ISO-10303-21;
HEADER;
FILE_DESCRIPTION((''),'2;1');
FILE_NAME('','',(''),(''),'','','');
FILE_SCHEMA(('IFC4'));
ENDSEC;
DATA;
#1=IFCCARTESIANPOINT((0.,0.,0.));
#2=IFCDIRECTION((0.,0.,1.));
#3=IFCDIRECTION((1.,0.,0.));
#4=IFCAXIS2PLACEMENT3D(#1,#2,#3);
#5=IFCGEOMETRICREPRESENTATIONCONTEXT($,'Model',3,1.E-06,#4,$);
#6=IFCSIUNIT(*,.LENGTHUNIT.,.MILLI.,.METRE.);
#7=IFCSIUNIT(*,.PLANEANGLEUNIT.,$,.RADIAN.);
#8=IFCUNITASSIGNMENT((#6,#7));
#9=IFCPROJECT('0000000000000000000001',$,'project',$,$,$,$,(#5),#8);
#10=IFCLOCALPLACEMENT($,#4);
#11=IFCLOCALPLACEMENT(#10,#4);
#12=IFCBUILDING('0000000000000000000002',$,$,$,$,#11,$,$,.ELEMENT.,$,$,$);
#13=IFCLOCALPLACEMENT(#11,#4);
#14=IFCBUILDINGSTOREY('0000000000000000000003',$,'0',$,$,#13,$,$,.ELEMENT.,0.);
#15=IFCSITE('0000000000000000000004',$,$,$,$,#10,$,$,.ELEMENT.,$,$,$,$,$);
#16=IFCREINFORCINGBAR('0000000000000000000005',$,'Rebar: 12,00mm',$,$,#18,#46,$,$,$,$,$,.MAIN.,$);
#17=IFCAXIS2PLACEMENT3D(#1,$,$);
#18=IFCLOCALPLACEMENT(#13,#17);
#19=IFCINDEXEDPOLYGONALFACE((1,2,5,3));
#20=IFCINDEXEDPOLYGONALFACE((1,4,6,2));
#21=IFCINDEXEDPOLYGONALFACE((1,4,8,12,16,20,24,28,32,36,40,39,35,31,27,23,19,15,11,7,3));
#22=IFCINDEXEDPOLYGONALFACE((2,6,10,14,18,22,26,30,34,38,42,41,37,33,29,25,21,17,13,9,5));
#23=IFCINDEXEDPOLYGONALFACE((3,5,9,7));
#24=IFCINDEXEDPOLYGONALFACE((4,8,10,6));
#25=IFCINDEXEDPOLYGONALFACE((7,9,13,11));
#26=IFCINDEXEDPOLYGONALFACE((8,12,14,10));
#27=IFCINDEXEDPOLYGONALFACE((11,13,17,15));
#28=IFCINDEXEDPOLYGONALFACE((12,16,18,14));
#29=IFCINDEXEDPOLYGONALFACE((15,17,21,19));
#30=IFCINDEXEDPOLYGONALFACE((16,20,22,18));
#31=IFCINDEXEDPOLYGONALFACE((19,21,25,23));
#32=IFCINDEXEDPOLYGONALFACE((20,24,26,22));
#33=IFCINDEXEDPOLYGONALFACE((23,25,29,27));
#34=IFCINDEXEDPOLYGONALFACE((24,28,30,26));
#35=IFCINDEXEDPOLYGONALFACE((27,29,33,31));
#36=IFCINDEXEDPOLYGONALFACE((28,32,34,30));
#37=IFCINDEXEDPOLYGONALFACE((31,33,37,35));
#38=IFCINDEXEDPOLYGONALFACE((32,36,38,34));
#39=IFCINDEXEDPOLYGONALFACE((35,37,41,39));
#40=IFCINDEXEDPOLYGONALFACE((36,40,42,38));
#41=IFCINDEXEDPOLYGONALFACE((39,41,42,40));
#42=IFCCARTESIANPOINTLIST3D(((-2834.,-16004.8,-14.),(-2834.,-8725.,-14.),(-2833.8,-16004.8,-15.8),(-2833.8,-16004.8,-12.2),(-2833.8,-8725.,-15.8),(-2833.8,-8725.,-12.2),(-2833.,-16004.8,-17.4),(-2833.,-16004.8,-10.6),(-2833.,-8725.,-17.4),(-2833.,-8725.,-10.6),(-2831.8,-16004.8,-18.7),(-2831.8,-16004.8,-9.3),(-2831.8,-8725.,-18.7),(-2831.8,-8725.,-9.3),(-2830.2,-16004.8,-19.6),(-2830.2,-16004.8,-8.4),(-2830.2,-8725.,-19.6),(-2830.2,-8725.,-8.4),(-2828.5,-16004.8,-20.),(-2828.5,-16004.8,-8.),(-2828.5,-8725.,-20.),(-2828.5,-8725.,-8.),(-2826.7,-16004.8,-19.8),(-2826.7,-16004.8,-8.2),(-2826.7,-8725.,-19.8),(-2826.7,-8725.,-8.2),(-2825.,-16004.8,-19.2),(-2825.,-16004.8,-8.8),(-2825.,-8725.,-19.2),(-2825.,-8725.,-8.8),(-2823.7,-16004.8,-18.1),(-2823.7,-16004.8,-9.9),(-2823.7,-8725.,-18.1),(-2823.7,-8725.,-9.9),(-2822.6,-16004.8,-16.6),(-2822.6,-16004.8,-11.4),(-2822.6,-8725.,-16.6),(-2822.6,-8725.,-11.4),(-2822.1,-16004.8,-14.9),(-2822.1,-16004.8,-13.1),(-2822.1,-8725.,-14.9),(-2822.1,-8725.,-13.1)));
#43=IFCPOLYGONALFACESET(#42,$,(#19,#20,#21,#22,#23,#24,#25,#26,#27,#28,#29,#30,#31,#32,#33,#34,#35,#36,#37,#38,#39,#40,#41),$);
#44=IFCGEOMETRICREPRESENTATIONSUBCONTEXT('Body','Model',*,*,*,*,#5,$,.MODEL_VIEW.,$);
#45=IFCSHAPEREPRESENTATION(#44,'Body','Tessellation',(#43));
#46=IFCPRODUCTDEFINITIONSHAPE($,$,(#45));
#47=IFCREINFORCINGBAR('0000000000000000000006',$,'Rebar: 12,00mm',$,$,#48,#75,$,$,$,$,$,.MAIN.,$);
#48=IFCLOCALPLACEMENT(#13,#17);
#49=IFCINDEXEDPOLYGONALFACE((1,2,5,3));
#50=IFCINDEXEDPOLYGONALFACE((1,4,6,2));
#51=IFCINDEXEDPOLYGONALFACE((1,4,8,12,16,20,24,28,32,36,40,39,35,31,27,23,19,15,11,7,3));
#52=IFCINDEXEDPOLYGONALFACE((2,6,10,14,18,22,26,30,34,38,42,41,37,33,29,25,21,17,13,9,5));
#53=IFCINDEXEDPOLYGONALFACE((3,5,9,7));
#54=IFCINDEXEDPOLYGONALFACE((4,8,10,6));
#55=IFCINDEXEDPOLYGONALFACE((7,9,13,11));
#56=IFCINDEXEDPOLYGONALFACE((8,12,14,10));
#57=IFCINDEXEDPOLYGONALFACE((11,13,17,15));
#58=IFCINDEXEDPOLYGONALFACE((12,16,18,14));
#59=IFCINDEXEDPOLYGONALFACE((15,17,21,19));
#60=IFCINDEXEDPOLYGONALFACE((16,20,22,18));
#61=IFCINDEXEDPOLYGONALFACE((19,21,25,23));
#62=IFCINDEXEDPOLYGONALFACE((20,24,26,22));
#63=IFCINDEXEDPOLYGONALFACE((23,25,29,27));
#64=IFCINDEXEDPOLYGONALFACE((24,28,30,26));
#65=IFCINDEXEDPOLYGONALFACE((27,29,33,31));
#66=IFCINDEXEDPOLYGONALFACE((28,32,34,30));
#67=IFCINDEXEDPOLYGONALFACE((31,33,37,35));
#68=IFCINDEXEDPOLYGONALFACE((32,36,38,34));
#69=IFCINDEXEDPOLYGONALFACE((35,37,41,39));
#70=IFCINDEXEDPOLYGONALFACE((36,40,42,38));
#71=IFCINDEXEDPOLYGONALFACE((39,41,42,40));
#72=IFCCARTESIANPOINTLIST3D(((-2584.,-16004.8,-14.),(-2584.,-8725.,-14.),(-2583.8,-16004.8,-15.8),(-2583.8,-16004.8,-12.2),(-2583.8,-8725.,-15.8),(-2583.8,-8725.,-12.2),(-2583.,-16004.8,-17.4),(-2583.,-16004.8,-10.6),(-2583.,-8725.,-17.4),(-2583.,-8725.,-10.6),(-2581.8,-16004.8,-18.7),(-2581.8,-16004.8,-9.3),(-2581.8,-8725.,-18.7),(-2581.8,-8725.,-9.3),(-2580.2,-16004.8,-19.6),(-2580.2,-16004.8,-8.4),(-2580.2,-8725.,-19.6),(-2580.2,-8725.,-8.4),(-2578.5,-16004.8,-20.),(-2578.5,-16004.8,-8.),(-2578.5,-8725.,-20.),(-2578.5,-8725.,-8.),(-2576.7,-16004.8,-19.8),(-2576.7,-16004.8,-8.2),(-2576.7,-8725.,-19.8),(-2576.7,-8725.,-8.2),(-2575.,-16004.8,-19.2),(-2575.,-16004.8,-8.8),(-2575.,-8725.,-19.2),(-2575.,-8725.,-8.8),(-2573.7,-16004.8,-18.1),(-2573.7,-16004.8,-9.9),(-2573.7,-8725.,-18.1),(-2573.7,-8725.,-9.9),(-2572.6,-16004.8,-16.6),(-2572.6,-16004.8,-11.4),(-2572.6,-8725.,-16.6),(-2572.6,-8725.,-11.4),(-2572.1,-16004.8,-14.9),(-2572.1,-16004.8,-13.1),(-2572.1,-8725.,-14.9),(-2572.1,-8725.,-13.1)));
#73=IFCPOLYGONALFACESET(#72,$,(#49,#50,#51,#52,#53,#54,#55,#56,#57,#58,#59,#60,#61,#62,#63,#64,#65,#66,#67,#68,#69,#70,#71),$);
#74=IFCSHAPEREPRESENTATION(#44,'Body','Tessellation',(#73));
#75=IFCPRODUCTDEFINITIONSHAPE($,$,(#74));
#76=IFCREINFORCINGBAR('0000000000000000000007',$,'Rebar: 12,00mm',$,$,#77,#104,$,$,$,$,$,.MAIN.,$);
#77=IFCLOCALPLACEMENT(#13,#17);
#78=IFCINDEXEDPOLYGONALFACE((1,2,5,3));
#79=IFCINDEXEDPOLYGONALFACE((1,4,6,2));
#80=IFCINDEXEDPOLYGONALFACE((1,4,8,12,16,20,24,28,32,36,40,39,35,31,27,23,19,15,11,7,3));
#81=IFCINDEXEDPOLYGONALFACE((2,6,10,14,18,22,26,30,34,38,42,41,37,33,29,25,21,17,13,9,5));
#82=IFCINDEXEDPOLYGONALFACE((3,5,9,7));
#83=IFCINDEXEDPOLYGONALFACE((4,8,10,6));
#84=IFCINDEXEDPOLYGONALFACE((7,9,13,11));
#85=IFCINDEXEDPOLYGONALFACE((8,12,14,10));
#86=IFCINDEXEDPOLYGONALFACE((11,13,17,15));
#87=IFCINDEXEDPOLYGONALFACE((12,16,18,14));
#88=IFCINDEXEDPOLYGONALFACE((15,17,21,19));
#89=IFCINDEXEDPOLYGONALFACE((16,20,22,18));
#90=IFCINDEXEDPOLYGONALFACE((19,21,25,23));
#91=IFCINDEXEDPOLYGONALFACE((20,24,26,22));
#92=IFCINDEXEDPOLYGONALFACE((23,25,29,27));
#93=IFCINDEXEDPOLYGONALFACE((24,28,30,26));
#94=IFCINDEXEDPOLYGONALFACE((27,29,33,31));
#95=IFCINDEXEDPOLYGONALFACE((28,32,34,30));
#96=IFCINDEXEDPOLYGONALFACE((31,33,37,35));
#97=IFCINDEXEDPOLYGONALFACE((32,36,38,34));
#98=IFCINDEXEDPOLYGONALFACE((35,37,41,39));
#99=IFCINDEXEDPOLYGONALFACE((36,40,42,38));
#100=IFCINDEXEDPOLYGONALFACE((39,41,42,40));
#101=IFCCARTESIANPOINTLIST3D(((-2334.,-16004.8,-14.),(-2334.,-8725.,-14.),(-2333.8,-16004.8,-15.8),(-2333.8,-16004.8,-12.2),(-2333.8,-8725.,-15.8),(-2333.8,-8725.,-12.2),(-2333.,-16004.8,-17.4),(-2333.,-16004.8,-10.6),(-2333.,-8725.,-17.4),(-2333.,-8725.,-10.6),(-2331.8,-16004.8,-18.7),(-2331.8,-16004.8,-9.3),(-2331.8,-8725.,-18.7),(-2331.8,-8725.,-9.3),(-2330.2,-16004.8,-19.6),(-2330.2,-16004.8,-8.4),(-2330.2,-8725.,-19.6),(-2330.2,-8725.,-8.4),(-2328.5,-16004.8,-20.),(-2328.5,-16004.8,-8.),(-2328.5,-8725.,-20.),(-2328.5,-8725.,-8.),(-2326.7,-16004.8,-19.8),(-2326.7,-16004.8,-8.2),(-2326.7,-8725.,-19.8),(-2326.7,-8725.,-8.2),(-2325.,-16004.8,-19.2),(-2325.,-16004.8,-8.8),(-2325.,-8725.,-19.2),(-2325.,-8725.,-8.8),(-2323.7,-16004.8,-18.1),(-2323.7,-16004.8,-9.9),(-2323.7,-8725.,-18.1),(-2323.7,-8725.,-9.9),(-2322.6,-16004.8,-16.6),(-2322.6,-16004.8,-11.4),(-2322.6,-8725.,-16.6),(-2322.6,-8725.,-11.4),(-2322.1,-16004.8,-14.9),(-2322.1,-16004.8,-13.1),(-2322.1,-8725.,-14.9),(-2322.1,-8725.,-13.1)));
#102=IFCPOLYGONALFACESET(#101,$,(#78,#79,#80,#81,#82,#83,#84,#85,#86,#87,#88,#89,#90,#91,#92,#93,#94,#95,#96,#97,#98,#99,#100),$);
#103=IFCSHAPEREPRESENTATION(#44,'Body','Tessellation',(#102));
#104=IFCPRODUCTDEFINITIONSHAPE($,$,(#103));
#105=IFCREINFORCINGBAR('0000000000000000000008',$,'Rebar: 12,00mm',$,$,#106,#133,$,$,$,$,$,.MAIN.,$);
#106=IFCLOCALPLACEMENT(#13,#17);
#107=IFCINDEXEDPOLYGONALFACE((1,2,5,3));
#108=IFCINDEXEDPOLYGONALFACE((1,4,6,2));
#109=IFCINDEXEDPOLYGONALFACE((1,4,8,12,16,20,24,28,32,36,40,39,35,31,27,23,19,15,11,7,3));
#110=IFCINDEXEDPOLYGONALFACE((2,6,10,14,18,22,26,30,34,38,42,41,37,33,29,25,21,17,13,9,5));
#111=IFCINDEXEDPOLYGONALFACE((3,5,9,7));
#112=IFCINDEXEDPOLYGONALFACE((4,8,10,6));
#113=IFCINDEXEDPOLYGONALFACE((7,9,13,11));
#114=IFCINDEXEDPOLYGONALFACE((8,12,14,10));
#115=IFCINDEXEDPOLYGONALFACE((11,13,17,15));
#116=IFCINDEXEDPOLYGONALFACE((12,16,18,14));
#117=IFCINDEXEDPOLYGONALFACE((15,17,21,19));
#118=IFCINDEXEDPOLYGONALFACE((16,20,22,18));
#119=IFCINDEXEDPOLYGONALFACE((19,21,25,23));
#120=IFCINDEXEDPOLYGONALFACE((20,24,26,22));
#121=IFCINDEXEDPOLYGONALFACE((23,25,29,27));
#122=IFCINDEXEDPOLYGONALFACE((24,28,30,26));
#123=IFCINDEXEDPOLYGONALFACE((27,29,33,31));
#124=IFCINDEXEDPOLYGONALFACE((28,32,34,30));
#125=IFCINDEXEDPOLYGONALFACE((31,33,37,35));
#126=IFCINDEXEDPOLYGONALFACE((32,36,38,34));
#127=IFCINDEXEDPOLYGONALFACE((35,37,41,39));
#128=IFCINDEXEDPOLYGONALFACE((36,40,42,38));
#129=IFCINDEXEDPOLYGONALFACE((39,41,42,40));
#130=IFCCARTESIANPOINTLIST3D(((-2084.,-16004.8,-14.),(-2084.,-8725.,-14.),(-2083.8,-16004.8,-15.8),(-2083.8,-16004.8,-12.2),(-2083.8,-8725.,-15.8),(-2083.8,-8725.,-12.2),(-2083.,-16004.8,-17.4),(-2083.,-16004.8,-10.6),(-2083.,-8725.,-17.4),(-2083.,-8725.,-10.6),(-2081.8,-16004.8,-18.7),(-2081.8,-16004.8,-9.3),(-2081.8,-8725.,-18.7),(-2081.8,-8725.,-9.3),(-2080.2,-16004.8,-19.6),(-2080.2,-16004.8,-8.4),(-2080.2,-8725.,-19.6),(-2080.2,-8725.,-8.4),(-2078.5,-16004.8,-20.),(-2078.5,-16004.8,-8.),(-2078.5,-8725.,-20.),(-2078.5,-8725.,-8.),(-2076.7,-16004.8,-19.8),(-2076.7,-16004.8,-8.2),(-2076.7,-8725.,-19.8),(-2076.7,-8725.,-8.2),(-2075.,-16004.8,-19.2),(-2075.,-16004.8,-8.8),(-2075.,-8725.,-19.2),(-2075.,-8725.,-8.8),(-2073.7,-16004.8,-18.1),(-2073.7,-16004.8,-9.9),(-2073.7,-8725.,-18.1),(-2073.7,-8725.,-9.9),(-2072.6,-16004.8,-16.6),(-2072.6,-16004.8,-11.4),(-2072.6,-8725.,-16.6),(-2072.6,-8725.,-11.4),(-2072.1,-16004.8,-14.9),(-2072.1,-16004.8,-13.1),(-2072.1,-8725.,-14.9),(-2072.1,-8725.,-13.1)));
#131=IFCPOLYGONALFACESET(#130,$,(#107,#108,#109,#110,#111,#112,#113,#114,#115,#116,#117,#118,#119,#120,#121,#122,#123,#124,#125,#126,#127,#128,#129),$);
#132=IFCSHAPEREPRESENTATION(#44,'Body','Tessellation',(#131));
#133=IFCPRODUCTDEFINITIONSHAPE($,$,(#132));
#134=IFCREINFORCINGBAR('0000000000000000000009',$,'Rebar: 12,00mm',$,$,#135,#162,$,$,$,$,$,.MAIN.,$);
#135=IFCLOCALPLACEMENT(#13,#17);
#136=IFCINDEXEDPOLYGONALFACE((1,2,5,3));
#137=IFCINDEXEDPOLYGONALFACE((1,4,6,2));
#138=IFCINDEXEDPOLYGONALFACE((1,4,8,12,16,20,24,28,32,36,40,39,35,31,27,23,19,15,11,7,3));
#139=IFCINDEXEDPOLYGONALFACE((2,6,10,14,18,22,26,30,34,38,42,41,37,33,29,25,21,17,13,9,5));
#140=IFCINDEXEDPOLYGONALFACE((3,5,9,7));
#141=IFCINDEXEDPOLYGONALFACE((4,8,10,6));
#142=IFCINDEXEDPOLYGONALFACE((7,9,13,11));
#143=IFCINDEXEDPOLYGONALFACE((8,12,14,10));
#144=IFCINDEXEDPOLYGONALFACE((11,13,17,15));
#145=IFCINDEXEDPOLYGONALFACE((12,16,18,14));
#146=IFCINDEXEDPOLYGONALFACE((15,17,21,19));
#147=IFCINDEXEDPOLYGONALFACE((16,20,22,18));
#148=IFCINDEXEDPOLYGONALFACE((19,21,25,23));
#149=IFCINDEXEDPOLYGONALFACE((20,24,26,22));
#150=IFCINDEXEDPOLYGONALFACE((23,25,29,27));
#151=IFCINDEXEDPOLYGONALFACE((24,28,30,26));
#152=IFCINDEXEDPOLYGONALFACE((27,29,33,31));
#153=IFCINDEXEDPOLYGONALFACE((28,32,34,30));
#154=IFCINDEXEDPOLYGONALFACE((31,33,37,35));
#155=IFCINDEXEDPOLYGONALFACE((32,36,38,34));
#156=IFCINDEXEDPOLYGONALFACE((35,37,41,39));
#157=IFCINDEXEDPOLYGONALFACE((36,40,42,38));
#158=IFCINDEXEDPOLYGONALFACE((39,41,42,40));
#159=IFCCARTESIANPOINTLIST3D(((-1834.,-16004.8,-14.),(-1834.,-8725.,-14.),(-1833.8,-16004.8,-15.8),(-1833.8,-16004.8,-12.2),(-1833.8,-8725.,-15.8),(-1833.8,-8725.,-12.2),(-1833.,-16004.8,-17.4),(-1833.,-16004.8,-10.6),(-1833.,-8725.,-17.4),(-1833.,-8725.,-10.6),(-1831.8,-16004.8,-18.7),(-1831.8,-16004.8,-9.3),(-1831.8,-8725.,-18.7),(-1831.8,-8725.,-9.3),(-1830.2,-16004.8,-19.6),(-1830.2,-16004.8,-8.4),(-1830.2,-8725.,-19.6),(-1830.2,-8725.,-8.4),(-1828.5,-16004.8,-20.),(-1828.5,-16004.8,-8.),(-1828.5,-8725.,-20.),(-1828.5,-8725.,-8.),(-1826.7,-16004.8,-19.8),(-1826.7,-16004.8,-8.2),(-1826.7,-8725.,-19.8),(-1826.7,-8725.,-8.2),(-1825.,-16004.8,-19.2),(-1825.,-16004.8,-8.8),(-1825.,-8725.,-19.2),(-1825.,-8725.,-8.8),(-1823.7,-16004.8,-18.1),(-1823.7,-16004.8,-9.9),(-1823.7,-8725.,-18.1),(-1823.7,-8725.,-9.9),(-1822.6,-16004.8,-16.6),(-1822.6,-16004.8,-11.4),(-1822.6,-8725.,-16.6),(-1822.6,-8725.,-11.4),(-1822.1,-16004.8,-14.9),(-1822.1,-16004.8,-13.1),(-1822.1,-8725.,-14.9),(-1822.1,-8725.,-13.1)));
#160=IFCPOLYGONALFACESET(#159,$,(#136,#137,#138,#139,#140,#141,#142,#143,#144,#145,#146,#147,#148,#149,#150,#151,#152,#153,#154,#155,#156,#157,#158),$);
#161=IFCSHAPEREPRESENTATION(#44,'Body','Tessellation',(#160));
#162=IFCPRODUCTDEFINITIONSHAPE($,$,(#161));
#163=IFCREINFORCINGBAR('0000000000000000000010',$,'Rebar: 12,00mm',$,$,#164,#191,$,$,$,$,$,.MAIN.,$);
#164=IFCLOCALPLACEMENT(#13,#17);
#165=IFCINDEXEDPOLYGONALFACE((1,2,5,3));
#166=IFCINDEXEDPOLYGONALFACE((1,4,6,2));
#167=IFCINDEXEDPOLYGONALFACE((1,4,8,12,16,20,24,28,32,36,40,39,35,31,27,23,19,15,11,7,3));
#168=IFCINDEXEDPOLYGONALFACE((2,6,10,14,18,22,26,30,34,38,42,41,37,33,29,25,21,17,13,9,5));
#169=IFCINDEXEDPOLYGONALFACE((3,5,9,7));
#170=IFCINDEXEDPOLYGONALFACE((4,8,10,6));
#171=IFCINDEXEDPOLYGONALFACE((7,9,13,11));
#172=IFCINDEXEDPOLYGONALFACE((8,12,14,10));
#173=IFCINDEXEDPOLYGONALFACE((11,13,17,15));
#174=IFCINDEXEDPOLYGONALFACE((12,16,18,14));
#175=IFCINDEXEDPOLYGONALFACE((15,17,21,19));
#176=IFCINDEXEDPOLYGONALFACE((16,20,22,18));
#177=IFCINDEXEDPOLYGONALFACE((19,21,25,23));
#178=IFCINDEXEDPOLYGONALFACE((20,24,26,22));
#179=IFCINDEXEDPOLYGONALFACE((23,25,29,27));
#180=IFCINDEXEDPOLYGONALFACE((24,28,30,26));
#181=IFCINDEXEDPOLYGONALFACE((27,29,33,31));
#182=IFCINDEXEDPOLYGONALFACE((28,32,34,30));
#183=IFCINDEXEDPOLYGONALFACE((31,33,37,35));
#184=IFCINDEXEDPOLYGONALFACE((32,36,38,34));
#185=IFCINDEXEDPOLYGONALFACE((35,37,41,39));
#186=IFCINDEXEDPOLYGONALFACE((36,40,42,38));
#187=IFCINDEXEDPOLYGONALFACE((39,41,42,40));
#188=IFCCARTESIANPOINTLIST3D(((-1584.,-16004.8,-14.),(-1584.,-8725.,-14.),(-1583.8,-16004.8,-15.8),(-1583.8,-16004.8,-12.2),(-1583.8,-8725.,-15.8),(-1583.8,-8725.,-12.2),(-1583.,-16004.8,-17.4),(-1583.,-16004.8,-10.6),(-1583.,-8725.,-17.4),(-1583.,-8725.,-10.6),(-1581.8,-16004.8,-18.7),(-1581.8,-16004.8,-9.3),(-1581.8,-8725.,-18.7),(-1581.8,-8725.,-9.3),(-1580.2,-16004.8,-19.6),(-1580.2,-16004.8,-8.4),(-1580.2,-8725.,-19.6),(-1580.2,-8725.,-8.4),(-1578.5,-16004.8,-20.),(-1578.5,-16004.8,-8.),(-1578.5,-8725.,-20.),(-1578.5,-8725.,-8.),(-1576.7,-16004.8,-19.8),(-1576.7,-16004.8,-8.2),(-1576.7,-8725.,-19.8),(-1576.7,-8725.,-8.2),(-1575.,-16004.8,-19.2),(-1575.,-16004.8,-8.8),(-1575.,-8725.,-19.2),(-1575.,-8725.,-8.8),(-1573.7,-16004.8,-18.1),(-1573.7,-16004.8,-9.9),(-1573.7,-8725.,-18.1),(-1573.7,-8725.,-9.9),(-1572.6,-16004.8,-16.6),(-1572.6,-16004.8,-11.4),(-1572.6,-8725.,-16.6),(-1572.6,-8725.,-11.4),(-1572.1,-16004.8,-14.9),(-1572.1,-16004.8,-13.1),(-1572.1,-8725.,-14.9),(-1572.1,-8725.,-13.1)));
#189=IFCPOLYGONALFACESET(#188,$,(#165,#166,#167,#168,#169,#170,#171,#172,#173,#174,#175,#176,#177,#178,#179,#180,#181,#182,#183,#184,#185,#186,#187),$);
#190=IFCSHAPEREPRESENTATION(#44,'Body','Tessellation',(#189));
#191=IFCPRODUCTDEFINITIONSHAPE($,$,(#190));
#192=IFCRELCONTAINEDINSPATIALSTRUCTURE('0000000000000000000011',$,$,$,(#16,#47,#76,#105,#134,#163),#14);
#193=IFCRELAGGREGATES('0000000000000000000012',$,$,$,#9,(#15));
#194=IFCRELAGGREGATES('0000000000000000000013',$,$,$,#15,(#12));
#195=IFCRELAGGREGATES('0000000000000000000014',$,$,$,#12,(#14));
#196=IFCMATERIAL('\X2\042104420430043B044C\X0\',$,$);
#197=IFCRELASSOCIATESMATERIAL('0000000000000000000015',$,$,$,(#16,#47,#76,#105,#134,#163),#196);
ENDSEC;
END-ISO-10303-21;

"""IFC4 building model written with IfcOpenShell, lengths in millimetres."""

from ifc_helpers import new_model, entity, si_unit, origin_with_axes, place, context, subcontext, project, spatial, source, transform, mapped, material, element, save


model = new_model("IFC4")

# Units and contexts
model_context = context("Model", 3, precision=1e-06, world=origin_with_axes())
body_context = subcontext(model_context, "Body", "Model", "MODEL_VIEW")
ifc_project = project(units=[si_unit("LENGTHUNIT", "METRE", prefix="MILLI"), si_unit("PLANEANGLEUNIT", "RADIAN")], contexts=[model_context])

# Site, building, storey
site_placement = place(None, origin_with_axes())
site = spatial("IfcSite", under=ifc_project, at=site_placement, CompositionType="ELEMENT")
building_placement = place(site_placement, origin_with_axes())
building = spatial("IfcBuilding", under=site, at=building_placement, CompositionType="ELEMENT")
storey_placement = place(building_placement, origin_with_axes())
storey = spatial("IfcBuildingStorey", under=building, at=storey_placement, Name="0", CompositionType="ELEMENT", Elevation=0.0)

# Reinforcing bars
ifc_material = material(Name="Сталь")
shared_shape = source(origin_with_axes(), body_context, "Body", "AdvancedSweptSolid", [
    entity("IfcSweptDiskSolid", entity("IfcIndexedPolyCurve", entity("IfcCartesianPointList3D", [[0.0, 0.0, 0.0], [7279.8, 0.0, 0.0]]), [entity("IfcLineIndex", [1, 2])]), 6.0),
])
reinforcing_bar_1_placement = place(storey_placement, origin_with_axes())
element("IfcReinforcingBar", 1, at=reinforcing_bar_1_placement, inside=storey, material=ifc_material, Name="Rebar: 12,00mm", PredefinedType="MAIN", context=body_context, shape_type="MappedRepresentation", body=[
    mapped(shared_shape, transform((-2828.0, -16004.8, -14.0), x_axis=(0.0, 1.0, 0.0), y_axis=(-1.0, 0.0, 0.0), z_axis=(0.0, 0.0, 1.0), scale=1.0)),
])
reinforcing_bar_2_placement = place(storey_placement, origin_with_axes())
element("IfcReinforcingBar", 2, at=reinforcing_bar_2_placement, inside=storey, material=ifc_material, Name="Rebar: 12,00mm", PredefinedType="MAIN", context=body_context, shape_type="MappedRepresentation", body=[
    mapped(shared_shape, transform((-2578.0, -16004.8, -14.0), x_axis=(0.0, 1.0, 0.0), y_axis=(-1.0, 0.0, 0.0), z_axis=(0.0, 0.0, 1.0), scale=1.0)),
])
reinforcing_bar_3_placement = place(storey_placement, origin_with_axes())
element("IfcReinforcingBar", 3, at=reinforcing_bar_3_placement, inside=storey, material=ifc_material, Name="Rebar: 12,00mm", PredefinedType="MAIN", context=body_context, shape_type="MappedRepresentation", body=[
    mapped(shared_shape, transform((-2328.0, -16004.8, -14.0), x_axis=(0.0, 1.0, 0.0), y_axis=(-1.0, 0.0, 0.0), z_axis=(0.0, 0.0, 1.0), scale=1.0)),
])
reinforcing_bar_4_placement = place(storey_placement, origin_with_axes())
element("IfcReinforcingBar", 4, at=reinforcing_bar_4_placement, inside=storey, material=ifc_material, Name="Rebar: 12,00mm", PredefinedType="MAIN", context=body_context, shape_type="MappedRepresentation", body=[
    mapped(shared_shape, transform((-2078.0, -16004.8, -14.0), x_axis=(0.0, 1.0, 0.0), y_axis=(-1.0, 0.0, 0.0), z_axis=(0.0, 0.0, 1.0), scale=1.0)),
])
reinforcing_bar_5_placement = place(storey_placement, origin_with_axes())
element("IfcReinforcingBar", 5, at=reinforcing_bar_5_placement, inside=storey, material=ifc_material, Name="Rebar: 12,00mm", PredefinedType="MAIN", context=body_context, shape_type="MappedRepresentation", body=[
    mapped(shared_shape, transform((-1828.0, -16004.8, -14.0), x_axis=(0.0, 1.0, 0.0), y_axis=(-1.0, 0.0, 0.0), z_axis=(0.0, 0.0, 1.0), scale=1.0)),
])
reinforcing_bar_6_placement = place(storey_placement, origin_with_axes())
element("IfcReinforcingBar", 6, at=reinforcing_bar_6_placement, inside=storey, material=ifc_material, Name="Rebar: 12,00mm", PredefinedType="MAIN", context=body_context, shape_type="MappedRepresentation", body=[
    mapped(shared_shape, transform((-1578.0, -16004.8, -14.0), x_axis=(0.0, 1.0, 0.0), y_axis=(-1.0, 0.0, 0.0), z_axis=(0.0, 0.0, 1.0), scale=1.0)),
])

save(model, "model.ifc")
